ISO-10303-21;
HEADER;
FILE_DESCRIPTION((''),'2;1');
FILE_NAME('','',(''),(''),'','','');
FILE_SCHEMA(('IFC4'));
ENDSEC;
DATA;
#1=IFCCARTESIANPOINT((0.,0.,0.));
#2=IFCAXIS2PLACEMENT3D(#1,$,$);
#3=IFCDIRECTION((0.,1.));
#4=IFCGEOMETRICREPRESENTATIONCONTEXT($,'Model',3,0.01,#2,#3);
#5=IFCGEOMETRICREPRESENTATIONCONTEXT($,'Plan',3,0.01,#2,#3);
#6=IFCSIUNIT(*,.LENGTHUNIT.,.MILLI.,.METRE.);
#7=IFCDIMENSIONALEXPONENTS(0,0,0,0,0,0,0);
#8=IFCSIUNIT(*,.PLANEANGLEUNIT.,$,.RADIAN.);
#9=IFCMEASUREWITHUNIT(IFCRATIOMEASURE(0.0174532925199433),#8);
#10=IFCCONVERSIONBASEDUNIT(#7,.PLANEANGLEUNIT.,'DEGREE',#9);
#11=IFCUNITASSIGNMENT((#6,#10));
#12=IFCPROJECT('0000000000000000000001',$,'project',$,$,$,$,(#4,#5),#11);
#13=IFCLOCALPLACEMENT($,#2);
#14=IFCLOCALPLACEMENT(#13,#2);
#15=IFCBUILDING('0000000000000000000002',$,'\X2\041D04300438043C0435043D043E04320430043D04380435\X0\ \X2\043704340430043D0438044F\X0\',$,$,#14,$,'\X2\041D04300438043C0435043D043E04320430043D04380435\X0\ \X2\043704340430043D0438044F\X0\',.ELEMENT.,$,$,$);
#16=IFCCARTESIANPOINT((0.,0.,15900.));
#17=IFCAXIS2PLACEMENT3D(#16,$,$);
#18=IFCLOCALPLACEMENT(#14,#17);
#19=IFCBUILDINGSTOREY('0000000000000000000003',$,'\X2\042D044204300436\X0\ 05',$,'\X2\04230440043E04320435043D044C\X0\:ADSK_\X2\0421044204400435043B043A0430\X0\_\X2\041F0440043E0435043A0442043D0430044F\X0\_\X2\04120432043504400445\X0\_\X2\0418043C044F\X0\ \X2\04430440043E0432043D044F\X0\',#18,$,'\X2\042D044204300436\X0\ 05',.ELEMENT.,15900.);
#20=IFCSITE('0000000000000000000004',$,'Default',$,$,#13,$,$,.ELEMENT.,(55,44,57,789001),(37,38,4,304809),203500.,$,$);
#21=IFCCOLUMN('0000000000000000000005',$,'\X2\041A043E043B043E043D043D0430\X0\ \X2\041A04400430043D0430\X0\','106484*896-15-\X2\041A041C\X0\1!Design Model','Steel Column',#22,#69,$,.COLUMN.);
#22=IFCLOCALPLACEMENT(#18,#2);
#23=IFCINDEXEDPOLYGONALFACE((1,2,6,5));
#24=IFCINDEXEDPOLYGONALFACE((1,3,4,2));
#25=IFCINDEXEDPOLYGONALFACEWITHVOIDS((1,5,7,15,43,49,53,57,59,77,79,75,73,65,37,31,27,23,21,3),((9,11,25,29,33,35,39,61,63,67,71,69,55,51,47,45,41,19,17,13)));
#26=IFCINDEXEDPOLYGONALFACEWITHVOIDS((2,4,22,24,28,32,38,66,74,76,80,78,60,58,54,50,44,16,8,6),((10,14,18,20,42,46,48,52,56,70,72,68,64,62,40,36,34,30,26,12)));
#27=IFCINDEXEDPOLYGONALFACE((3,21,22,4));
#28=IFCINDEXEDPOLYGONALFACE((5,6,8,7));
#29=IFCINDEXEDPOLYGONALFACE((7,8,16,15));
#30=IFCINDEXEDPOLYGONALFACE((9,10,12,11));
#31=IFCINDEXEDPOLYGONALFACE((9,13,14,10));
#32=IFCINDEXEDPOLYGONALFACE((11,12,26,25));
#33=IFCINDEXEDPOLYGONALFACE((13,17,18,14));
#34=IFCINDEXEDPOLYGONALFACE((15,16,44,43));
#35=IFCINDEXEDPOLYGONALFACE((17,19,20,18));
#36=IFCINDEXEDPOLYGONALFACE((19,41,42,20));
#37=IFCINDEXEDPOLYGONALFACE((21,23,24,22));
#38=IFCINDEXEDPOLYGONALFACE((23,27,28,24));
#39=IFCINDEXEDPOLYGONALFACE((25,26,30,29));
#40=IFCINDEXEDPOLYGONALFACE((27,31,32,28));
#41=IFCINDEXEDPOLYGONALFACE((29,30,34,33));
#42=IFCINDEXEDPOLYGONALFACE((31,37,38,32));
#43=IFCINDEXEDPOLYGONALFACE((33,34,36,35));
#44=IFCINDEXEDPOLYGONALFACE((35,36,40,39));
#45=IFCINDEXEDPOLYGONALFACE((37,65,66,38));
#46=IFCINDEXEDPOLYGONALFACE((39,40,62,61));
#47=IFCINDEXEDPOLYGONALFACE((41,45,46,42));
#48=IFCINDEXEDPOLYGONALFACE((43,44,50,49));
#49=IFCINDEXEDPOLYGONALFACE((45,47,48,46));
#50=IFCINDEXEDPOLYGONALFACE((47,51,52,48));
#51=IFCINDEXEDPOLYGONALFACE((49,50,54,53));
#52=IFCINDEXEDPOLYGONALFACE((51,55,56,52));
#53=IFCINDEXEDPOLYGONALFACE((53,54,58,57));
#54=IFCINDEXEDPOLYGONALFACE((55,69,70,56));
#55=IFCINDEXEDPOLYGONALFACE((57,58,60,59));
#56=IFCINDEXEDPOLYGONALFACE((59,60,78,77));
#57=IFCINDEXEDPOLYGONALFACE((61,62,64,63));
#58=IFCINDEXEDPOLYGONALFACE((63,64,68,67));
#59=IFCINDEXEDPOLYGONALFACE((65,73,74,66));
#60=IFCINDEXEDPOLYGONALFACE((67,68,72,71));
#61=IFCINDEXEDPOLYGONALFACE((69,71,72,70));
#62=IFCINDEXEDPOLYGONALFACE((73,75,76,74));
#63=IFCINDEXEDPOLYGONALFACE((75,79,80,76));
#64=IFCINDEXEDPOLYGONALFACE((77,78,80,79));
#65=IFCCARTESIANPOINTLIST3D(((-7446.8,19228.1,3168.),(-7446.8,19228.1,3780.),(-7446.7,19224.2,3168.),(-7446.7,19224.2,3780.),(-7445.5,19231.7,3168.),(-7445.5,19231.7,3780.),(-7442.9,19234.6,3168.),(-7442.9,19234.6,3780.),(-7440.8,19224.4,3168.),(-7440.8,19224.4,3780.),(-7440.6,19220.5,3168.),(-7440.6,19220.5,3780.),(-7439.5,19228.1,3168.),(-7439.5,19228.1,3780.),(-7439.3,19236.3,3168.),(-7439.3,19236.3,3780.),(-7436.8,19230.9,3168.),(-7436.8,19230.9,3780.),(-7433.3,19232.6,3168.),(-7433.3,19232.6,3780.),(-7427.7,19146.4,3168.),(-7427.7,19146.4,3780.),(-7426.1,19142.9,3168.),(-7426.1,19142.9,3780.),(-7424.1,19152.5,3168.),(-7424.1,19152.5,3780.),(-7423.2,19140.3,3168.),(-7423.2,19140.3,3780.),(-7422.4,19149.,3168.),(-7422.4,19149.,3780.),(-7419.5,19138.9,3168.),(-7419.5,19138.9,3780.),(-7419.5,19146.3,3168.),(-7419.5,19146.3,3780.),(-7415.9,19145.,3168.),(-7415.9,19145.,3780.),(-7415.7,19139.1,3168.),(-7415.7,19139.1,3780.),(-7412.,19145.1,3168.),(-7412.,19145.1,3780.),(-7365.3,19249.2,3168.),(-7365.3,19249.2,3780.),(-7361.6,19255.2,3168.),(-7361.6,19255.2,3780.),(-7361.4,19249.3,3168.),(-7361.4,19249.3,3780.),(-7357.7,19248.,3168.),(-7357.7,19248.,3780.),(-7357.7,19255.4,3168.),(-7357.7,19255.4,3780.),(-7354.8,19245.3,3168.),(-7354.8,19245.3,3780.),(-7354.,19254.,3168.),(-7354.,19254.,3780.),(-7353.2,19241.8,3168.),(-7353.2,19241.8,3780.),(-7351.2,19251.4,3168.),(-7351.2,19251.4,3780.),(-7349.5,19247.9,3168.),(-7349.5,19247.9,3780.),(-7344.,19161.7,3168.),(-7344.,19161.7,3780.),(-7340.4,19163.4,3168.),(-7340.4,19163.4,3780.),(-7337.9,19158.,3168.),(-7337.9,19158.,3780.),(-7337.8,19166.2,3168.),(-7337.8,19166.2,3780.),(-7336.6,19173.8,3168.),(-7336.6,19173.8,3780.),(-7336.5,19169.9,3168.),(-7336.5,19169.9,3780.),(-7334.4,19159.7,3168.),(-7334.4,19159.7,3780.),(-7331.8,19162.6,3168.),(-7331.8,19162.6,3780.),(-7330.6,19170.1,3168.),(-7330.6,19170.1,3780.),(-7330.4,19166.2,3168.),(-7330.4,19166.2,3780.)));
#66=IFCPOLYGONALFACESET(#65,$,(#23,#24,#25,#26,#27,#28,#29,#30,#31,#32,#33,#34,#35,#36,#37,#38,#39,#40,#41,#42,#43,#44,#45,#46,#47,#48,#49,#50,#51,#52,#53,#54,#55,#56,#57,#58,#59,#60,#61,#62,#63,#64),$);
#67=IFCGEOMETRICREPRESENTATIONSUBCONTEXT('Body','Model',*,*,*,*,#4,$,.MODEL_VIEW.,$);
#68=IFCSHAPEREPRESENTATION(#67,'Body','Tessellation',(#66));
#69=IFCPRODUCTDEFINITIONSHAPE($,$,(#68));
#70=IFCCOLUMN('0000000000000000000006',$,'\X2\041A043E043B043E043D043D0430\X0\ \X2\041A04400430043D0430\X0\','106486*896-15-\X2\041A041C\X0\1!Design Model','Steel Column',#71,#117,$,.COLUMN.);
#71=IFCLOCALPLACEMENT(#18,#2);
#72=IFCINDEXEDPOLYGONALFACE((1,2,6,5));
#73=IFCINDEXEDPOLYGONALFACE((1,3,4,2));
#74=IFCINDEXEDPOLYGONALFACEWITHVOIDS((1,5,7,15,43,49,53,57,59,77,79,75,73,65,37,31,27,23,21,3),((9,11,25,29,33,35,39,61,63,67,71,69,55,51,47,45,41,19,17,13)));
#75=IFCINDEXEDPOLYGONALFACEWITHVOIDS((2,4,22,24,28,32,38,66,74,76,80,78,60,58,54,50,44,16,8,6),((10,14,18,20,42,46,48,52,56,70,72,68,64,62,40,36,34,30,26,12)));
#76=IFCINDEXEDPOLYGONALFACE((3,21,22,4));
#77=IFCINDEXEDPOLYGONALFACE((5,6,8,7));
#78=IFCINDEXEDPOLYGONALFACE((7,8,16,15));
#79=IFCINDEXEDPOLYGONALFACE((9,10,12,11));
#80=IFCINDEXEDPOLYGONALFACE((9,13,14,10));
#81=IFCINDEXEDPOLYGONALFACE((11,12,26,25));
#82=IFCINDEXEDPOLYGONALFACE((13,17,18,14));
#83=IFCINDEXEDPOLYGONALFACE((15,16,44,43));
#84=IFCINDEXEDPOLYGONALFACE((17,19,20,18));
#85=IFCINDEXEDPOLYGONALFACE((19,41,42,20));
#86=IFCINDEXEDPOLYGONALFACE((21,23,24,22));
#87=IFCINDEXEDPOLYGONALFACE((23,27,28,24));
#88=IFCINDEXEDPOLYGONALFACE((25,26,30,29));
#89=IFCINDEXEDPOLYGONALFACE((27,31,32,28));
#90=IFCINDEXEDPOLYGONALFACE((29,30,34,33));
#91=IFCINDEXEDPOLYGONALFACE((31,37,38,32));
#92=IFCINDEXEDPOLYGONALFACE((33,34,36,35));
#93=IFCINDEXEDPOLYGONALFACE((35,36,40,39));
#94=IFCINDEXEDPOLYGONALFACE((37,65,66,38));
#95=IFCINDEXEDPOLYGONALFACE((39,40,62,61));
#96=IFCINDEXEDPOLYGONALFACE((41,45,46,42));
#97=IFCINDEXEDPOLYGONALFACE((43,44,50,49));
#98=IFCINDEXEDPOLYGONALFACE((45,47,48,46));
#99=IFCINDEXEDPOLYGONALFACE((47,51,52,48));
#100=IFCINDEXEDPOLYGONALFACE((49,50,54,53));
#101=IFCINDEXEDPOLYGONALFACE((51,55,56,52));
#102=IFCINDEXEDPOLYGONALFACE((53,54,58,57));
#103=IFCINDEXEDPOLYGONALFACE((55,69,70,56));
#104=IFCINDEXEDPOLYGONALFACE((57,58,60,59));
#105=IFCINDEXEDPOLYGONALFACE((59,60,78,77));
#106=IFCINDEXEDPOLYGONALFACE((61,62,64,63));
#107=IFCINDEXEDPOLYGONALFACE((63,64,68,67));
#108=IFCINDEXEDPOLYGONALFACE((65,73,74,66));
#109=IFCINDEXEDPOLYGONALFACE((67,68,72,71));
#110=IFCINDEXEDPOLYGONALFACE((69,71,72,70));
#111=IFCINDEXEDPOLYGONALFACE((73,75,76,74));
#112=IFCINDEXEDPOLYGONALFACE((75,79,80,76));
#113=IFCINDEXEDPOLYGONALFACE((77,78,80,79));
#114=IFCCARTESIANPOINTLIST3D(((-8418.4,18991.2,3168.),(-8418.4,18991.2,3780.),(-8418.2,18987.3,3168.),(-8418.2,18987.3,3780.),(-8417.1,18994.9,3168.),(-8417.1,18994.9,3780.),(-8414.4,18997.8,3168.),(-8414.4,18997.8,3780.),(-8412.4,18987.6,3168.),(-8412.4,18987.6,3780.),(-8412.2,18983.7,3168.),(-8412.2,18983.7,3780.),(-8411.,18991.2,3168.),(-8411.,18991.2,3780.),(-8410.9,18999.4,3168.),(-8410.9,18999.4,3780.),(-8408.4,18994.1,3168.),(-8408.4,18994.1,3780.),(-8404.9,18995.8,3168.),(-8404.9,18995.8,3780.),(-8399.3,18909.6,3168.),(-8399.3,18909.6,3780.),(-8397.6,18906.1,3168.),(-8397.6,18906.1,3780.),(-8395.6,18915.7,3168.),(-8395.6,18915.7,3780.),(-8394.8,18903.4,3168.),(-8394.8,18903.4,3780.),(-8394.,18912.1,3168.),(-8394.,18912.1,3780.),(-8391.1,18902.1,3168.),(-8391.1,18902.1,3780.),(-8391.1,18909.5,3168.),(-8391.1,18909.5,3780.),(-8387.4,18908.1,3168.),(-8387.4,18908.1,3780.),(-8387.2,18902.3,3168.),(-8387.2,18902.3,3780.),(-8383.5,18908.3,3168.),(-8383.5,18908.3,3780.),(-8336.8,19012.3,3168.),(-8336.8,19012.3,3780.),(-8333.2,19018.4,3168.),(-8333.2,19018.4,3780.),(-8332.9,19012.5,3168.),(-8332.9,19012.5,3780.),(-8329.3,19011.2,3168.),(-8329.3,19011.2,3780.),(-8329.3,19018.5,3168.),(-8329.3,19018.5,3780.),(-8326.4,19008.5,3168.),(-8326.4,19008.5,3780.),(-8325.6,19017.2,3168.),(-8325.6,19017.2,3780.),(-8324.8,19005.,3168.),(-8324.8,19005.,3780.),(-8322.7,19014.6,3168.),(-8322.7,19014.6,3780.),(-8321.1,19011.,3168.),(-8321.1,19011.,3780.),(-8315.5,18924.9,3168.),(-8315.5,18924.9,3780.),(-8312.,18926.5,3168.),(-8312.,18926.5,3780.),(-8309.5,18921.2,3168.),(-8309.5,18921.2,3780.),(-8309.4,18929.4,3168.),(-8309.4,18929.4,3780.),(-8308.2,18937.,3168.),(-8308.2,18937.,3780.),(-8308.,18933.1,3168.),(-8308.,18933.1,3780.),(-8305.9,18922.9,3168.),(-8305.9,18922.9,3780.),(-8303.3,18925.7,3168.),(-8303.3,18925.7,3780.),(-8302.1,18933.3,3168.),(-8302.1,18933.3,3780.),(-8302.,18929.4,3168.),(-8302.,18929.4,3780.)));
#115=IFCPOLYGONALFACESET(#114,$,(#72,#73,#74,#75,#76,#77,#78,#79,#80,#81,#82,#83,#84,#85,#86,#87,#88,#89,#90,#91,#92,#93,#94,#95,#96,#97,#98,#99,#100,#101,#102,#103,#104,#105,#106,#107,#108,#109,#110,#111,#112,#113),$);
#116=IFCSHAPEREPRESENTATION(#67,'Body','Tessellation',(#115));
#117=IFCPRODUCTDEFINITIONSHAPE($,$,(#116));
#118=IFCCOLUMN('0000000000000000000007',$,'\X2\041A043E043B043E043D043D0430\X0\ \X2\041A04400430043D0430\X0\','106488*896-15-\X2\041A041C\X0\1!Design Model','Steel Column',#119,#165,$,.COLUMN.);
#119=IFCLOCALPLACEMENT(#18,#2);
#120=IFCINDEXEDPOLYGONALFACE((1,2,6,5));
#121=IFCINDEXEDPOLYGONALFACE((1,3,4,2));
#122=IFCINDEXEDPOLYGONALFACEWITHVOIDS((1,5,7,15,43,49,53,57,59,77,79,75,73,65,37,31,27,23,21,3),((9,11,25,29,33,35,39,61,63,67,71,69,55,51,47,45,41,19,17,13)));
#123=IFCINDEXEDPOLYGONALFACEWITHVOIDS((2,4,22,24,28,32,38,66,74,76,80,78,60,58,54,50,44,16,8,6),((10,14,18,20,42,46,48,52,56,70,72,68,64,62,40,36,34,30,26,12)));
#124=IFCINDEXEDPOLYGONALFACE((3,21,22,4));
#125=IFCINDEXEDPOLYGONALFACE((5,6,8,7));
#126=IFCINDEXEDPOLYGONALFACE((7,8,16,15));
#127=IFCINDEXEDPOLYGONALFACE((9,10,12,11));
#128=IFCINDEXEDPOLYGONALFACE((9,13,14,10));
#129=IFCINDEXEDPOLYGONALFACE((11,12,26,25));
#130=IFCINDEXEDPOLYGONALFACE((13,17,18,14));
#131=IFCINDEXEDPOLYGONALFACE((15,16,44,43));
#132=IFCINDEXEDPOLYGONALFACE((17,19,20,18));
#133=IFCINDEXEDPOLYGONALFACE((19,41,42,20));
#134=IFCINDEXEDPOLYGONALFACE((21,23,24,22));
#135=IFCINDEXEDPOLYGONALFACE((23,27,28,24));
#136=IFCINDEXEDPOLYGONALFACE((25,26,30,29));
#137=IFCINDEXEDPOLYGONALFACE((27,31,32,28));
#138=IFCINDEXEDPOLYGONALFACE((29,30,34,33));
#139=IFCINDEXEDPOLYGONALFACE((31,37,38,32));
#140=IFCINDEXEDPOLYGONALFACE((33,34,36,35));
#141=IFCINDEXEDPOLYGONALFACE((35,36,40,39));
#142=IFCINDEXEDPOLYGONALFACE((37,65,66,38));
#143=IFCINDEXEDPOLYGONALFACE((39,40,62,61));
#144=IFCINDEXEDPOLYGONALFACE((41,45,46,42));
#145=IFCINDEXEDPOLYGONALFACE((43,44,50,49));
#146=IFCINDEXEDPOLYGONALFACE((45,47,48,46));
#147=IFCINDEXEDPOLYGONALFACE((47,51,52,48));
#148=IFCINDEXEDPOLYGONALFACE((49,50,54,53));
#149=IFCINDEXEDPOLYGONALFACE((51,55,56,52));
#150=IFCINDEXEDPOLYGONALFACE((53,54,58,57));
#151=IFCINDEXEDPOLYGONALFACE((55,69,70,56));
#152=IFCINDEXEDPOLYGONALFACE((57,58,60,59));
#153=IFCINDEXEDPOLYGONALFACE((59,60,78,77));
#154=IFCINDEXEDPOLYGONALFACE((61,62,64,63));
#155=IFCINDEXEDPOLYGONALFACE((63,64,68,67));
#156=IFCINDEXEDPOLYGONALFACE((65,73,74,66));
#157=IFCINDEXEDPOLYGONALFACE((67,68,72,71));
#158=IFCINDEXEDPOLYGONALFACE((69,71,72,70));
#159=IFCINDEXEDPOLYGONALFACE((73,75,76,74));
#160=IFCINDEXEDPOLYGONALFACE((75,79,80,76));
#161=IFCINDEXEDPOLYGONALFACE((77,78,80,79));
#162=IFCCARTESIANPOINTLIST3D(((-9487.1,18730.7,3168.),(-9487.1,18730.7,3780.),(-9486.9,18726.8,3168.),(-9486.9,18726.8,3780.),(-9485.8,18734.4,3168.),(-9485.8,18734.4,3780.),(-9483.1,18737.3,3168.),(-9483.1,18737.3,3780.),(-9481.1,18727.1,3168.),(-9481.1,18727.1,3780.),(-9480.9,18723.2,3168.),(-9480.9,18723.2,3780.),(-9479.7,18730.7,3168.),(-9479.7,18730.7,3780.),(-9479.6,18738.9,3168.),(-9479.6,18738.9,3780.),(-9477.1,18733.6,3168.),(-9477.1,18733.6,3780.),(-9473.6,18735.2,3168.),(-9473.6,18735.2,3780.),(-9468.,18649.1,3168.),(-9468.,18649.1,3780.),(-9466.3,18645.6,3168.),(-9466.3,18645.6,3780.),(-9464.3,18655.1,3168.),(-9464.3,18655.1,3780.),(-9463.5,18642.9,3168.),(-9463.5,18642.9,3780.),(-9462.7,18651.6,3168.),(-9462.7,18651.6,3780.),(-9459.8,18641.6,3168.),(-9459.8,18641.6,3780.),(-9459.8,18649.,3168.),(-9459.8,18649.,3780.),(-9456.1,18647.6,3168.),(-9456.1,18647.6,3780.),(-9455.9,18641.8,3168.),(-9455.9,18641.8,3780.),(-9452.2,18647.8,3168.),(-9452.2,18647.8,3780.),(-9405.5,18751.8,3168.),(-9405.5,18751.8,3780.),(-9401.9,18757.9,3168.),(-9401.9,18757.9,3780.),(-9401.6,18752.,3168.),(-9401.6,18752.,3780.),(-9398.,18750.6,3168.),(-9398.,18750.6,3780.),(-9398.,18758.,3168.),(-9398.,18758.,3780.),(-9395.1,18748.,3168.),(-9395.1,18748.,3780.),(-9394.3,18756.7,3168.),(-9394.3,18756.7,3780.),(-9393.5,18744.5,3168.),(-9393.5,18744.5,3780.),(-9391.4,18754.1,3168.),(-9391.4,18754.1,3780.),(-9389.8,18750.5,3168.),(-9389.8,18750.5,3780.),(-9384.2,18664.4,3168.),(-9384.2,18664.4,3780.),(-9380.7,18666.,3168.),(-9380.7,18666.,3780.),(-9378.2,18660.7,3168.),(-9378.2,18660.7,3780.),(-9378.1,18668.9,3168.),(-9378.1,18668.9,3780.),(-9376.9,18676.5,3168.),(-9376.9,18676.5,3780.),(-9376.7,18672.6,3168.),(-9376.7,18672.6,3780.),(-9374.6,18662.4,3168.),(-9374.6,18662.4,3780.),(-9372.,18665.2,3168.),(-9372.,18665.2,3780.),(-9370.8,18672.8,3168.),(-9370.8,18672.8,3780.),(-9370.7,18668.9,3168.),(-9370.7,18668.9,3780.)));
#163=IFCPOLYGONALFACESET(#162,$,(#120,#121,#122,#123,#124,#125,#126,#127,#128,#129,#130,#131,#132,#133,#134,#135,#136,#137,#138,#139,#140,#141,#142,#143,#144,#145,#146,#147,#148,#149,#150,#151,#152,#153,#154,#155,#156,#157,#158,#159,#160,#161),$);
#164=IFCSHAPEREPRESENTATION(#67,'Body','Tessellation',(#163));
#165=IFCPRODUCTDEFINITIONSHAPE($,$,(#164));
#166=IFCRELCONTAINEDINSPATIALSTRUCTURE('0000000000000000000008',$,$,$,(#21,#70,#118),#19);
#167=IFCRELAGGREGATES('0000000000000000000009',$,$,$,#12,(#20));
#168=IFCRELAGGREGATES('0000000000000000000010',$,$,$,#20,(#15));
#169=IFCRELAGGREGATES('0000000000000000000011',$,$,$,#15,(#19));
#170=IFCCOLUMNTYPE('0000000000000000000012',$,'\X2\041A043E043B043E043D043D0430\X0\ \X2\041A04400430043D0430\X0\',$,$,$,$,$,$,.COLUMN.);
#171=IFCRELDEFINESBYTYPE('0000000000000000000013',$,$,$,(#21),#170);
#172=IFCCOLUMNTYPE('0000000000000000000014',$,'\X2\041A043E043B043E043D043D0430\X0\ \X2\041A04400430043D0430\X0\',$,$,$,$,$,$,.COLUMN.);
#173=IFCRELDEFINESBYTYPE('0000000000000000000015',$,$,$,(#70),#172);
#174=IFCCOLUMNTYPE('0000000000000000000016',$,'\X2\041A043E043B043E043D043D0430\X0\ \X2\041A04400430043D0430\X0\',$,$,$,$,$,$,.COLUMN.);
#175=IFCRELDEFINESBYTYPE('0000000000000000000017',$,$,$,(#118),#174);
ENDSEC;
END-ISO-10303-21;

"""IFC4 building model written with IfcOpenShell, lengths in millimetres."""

from ifc_helpers import new_model, entity, si_unit, converted_unit, direction, frame, origin, place, context, subcontext, project, spatial, indexed_curve, outline, extrude, type_object, element, save


model = new_model("IFC4")

# Units and contexts
model_context = context("Model", 3, precision=0.01, world=origin(), true_north=direction((0.0, 1.0)))
plan_context = context("Plan", 3, precision=0.01, world=origin(), true_north=direction((0.0, 1.0)))
body_context = subcontext(model_context, "Body", "Model", "MODEL_VIEW")
ifc_project = project(units=[si_unit("LENGTHUNIT", "METRE", prefix="MILLI"), converted_unit("PLANEANGLEUNIT", "DEGREE", entity("IfcRatioMeasure", 0.0174532925199433), si_unit("PLANEANGLEUNIT", "RADIAN"), dimensions=[0, 0, 0, 0, 0, 0, 0])], contexts=[model_context, plan_context])

# Site, building, storey
site_placement = place(None, origin())
site = spatial("IfcSite", under=ifc_project, at=site_placement, Name="Default", CompositionType="ELEMENT", RefLatitude=(55, 44, 57, 789001), RefLongitude=(37, 38, 4, 304809), RefElevation=203500.0)
building_placement = place(site_placement, origin())
building = spatial("IfcBuilding", under=site, at=building_placement, Name="Наименование здания", LongName="Наименование здания", CompositionType="ELEMENT")
storey_placement = place(building_placement, frame((0.0, 0.0, 15900.0)))
storey = spatial("IfcBuildingStorey", under=building, at=storey_placement, Name="Этаж 05", ObjectType="Уровень:ADSK_Стрелка_Проектная_Вверх_Имя уровня", LongName="Этаж 05", CompositionType="ELEMENT", Elevation=15900.0)

# Columns
placement = place(storey_placement, origin())
column_type_1 = type_object("IfcColumnType", Name="Колонна Крана", PredefinedType="COLUMN")
element("IfcColumn", 1, at=placement, inside=storey, type_object=column_type_1, Name="Колонна Крана", Description="106484*896-15-КМ1!Design Model", ObjectType="Steel Column", PredefinedType="COLUMN", context=body_context, shape_type="SweptSolid", body=[
    extrude(outline(indexed_curve([(29.5, -56.8), (33.4, -56.8), (37.0, -55.3), (39.7, -52.6), (41.2, -49.0), (56.8, 29.5), (56.8, 33.4), (55.3, 37.0), (52.6, 39.7), (49.0, 41.2), (-29.5, 56.8), (-33.4, 56.8), (-37.0, 55.3), (-39.7, 52.6), (-41.2, 49.0), (-56.8, -29.5), (-56.8, -33.4), (-55.3, -37.0), (-52.6, -39.7), (-49.0, -41.2), (29.5, -56.8)], self_intersect=False), holes=[indexed_curve([(-43.1, -37.3), (-46.7, -35.8), (-49.5, -33.1), (-51.0, -29.5), (-51.0, -25.5), (-37.3, 43.1), (-35.8, 46.7), (-33.1, 49.5), (-29.5, 51.0), (-25.5, 51.0), (43.1, 37.3), (46.7, 35.8), (49.5, 33.1), (51.0, 29.5), (51.0, 25.5), (37.3, -43.1), (35.8, -46.7), (33.1, -49.5), (29.5, -51.0), (25.5, -51.0), (-43.1, -37.3)], self_intersect=False)]), frame((-7388.6, 19197.2, 3168.0), z_axis=(0.0, 0.0, 1.0), x_axis=(0.906681, 0.421816, 0.0)), (0.0, 0.0, 1.0), 612.0),
])
column_type_2 = type_object("IfcColumnType", Name="Колонна Крана", PredefinedType="COLUMN")
element("IfcColumn", 2, at=placement, inside=storey, type_object=column_type_2, Name="Колонна Крана", Description="106486*896-15-КМ1!Design Model", ObjectType="Steel Column", PredefinedType="COLUMN", context=body_context, shape_type="SweptSolid", body=[
    extrude(outline(indexed_curve([(29.5, -56.8), (33.4, -56.8), (37.0, -55.3), (39.7, -52.6), (41.2, -49.0), (56.8, 29.5), (56.8, 33.4), (55.3, 37.0), (52.6, 39.7), (49.0, 41.2), (-29.5, 56.8), (-33.4, 56.8), (-37.0, 55.3), (-39.7, 52.6), (-41.2, 49.0), (-56.8, -29.5), (-56.8, -33.4), (-55.3, -37.0), (-52.6, -39.7), (-49.0, -41.2), (29.5, -56.8)], self_intersect=False), holes=[indexed_curve([(-43.1, -37.3), (-46.7, -35.8), (-49.5, -33.1), (-51.0, -29.5), (-51.0, -25.5), (-37.3, 43.1), (-35.8, 46.7), (-33.1, 49.5), (-29.5, 51.0), (-25.5, 51.0), (43.1, 37.3), (46.7, 35.8), (49.5, 33.1), (51.0, 29.5), (51.0, 25.5), (37.3, -43.1), (35.8, -46.7), (33.1, -49.5), (29.5, -51.0), (25.5, -51.0), (-43.1, -37.3)], self_intersect=False)]), frame((-8360.2, 18960.3, 3168.0), z_axis=(0.0, 0.0, 1.0), x_axis=(0.906681, 0.421816, 0.0)), (0.0, 0.0, 1.0), 612.0),
])
column_type_3 = type_object("IfcColumnType", Name="Колонна Крана", PredefinedType="COLUMN")
element("IfcColumn", 3, at=placement, inside=storey, type_object=column_type_3, Name="Колонна Крана", Description="106488*896-15-КМ1!Design Model", ObjectType="Steel Column", PredefinedType="COLUMN", context=body_context, shape_type="SweptSolid", body=[
    extrude(outline(indexed_curve([(29.5, -56.8), (33.4, -56.8), (37.0, -55.3), (39.7, -52.6), (41.2, -49.0), (56.8, 29.5), (56.8, 33.4), (55.3, 37.0), (52.6, 39.7), (49.0, 41.2), (-29.5, 56.8), (-33.4, 56.8), (-37.0, 55.3), (-39.7, 52.6), (-41.2, 49.0), (-56.8, -29.5), (-56.8, -33.4), (-55.3, -37.0), (-52.6, -39.7), (-49.0, -41.2), (29.5, -56.8)], self_intersect=False), holes=[indexed_curve([(-43.1, -37.3), (-46.7, -35.8), (-49.5, -33.1), (-51.0, -29.5), (-51.0, -25.5), (-37.3, 43.1), (-35.8, 46.7), (-33.1, 49.5), (-29.5, 51.0), (-25.5, 51.0), (43.1, 37.3), (46.7, 35.8), (49.5, 33.1), (51.0, 29.5), (51.0, 25.5), (37.3, -43.1), (35.8, -46.7), (33.1, -49.5), (29.5, -51.0), (25.5, -51.0), (-43.1, -37.3)], self_intersect=False)]), frame((-9428.9, 18699.8, 3168.0), z_axis=(0.0, 0.0, 1.0), x_axis=(0.906681, 0.421816, 0.0)), (0.0, 0.0, 1.0), 612.0),
])

save(model, "model.ifc")
